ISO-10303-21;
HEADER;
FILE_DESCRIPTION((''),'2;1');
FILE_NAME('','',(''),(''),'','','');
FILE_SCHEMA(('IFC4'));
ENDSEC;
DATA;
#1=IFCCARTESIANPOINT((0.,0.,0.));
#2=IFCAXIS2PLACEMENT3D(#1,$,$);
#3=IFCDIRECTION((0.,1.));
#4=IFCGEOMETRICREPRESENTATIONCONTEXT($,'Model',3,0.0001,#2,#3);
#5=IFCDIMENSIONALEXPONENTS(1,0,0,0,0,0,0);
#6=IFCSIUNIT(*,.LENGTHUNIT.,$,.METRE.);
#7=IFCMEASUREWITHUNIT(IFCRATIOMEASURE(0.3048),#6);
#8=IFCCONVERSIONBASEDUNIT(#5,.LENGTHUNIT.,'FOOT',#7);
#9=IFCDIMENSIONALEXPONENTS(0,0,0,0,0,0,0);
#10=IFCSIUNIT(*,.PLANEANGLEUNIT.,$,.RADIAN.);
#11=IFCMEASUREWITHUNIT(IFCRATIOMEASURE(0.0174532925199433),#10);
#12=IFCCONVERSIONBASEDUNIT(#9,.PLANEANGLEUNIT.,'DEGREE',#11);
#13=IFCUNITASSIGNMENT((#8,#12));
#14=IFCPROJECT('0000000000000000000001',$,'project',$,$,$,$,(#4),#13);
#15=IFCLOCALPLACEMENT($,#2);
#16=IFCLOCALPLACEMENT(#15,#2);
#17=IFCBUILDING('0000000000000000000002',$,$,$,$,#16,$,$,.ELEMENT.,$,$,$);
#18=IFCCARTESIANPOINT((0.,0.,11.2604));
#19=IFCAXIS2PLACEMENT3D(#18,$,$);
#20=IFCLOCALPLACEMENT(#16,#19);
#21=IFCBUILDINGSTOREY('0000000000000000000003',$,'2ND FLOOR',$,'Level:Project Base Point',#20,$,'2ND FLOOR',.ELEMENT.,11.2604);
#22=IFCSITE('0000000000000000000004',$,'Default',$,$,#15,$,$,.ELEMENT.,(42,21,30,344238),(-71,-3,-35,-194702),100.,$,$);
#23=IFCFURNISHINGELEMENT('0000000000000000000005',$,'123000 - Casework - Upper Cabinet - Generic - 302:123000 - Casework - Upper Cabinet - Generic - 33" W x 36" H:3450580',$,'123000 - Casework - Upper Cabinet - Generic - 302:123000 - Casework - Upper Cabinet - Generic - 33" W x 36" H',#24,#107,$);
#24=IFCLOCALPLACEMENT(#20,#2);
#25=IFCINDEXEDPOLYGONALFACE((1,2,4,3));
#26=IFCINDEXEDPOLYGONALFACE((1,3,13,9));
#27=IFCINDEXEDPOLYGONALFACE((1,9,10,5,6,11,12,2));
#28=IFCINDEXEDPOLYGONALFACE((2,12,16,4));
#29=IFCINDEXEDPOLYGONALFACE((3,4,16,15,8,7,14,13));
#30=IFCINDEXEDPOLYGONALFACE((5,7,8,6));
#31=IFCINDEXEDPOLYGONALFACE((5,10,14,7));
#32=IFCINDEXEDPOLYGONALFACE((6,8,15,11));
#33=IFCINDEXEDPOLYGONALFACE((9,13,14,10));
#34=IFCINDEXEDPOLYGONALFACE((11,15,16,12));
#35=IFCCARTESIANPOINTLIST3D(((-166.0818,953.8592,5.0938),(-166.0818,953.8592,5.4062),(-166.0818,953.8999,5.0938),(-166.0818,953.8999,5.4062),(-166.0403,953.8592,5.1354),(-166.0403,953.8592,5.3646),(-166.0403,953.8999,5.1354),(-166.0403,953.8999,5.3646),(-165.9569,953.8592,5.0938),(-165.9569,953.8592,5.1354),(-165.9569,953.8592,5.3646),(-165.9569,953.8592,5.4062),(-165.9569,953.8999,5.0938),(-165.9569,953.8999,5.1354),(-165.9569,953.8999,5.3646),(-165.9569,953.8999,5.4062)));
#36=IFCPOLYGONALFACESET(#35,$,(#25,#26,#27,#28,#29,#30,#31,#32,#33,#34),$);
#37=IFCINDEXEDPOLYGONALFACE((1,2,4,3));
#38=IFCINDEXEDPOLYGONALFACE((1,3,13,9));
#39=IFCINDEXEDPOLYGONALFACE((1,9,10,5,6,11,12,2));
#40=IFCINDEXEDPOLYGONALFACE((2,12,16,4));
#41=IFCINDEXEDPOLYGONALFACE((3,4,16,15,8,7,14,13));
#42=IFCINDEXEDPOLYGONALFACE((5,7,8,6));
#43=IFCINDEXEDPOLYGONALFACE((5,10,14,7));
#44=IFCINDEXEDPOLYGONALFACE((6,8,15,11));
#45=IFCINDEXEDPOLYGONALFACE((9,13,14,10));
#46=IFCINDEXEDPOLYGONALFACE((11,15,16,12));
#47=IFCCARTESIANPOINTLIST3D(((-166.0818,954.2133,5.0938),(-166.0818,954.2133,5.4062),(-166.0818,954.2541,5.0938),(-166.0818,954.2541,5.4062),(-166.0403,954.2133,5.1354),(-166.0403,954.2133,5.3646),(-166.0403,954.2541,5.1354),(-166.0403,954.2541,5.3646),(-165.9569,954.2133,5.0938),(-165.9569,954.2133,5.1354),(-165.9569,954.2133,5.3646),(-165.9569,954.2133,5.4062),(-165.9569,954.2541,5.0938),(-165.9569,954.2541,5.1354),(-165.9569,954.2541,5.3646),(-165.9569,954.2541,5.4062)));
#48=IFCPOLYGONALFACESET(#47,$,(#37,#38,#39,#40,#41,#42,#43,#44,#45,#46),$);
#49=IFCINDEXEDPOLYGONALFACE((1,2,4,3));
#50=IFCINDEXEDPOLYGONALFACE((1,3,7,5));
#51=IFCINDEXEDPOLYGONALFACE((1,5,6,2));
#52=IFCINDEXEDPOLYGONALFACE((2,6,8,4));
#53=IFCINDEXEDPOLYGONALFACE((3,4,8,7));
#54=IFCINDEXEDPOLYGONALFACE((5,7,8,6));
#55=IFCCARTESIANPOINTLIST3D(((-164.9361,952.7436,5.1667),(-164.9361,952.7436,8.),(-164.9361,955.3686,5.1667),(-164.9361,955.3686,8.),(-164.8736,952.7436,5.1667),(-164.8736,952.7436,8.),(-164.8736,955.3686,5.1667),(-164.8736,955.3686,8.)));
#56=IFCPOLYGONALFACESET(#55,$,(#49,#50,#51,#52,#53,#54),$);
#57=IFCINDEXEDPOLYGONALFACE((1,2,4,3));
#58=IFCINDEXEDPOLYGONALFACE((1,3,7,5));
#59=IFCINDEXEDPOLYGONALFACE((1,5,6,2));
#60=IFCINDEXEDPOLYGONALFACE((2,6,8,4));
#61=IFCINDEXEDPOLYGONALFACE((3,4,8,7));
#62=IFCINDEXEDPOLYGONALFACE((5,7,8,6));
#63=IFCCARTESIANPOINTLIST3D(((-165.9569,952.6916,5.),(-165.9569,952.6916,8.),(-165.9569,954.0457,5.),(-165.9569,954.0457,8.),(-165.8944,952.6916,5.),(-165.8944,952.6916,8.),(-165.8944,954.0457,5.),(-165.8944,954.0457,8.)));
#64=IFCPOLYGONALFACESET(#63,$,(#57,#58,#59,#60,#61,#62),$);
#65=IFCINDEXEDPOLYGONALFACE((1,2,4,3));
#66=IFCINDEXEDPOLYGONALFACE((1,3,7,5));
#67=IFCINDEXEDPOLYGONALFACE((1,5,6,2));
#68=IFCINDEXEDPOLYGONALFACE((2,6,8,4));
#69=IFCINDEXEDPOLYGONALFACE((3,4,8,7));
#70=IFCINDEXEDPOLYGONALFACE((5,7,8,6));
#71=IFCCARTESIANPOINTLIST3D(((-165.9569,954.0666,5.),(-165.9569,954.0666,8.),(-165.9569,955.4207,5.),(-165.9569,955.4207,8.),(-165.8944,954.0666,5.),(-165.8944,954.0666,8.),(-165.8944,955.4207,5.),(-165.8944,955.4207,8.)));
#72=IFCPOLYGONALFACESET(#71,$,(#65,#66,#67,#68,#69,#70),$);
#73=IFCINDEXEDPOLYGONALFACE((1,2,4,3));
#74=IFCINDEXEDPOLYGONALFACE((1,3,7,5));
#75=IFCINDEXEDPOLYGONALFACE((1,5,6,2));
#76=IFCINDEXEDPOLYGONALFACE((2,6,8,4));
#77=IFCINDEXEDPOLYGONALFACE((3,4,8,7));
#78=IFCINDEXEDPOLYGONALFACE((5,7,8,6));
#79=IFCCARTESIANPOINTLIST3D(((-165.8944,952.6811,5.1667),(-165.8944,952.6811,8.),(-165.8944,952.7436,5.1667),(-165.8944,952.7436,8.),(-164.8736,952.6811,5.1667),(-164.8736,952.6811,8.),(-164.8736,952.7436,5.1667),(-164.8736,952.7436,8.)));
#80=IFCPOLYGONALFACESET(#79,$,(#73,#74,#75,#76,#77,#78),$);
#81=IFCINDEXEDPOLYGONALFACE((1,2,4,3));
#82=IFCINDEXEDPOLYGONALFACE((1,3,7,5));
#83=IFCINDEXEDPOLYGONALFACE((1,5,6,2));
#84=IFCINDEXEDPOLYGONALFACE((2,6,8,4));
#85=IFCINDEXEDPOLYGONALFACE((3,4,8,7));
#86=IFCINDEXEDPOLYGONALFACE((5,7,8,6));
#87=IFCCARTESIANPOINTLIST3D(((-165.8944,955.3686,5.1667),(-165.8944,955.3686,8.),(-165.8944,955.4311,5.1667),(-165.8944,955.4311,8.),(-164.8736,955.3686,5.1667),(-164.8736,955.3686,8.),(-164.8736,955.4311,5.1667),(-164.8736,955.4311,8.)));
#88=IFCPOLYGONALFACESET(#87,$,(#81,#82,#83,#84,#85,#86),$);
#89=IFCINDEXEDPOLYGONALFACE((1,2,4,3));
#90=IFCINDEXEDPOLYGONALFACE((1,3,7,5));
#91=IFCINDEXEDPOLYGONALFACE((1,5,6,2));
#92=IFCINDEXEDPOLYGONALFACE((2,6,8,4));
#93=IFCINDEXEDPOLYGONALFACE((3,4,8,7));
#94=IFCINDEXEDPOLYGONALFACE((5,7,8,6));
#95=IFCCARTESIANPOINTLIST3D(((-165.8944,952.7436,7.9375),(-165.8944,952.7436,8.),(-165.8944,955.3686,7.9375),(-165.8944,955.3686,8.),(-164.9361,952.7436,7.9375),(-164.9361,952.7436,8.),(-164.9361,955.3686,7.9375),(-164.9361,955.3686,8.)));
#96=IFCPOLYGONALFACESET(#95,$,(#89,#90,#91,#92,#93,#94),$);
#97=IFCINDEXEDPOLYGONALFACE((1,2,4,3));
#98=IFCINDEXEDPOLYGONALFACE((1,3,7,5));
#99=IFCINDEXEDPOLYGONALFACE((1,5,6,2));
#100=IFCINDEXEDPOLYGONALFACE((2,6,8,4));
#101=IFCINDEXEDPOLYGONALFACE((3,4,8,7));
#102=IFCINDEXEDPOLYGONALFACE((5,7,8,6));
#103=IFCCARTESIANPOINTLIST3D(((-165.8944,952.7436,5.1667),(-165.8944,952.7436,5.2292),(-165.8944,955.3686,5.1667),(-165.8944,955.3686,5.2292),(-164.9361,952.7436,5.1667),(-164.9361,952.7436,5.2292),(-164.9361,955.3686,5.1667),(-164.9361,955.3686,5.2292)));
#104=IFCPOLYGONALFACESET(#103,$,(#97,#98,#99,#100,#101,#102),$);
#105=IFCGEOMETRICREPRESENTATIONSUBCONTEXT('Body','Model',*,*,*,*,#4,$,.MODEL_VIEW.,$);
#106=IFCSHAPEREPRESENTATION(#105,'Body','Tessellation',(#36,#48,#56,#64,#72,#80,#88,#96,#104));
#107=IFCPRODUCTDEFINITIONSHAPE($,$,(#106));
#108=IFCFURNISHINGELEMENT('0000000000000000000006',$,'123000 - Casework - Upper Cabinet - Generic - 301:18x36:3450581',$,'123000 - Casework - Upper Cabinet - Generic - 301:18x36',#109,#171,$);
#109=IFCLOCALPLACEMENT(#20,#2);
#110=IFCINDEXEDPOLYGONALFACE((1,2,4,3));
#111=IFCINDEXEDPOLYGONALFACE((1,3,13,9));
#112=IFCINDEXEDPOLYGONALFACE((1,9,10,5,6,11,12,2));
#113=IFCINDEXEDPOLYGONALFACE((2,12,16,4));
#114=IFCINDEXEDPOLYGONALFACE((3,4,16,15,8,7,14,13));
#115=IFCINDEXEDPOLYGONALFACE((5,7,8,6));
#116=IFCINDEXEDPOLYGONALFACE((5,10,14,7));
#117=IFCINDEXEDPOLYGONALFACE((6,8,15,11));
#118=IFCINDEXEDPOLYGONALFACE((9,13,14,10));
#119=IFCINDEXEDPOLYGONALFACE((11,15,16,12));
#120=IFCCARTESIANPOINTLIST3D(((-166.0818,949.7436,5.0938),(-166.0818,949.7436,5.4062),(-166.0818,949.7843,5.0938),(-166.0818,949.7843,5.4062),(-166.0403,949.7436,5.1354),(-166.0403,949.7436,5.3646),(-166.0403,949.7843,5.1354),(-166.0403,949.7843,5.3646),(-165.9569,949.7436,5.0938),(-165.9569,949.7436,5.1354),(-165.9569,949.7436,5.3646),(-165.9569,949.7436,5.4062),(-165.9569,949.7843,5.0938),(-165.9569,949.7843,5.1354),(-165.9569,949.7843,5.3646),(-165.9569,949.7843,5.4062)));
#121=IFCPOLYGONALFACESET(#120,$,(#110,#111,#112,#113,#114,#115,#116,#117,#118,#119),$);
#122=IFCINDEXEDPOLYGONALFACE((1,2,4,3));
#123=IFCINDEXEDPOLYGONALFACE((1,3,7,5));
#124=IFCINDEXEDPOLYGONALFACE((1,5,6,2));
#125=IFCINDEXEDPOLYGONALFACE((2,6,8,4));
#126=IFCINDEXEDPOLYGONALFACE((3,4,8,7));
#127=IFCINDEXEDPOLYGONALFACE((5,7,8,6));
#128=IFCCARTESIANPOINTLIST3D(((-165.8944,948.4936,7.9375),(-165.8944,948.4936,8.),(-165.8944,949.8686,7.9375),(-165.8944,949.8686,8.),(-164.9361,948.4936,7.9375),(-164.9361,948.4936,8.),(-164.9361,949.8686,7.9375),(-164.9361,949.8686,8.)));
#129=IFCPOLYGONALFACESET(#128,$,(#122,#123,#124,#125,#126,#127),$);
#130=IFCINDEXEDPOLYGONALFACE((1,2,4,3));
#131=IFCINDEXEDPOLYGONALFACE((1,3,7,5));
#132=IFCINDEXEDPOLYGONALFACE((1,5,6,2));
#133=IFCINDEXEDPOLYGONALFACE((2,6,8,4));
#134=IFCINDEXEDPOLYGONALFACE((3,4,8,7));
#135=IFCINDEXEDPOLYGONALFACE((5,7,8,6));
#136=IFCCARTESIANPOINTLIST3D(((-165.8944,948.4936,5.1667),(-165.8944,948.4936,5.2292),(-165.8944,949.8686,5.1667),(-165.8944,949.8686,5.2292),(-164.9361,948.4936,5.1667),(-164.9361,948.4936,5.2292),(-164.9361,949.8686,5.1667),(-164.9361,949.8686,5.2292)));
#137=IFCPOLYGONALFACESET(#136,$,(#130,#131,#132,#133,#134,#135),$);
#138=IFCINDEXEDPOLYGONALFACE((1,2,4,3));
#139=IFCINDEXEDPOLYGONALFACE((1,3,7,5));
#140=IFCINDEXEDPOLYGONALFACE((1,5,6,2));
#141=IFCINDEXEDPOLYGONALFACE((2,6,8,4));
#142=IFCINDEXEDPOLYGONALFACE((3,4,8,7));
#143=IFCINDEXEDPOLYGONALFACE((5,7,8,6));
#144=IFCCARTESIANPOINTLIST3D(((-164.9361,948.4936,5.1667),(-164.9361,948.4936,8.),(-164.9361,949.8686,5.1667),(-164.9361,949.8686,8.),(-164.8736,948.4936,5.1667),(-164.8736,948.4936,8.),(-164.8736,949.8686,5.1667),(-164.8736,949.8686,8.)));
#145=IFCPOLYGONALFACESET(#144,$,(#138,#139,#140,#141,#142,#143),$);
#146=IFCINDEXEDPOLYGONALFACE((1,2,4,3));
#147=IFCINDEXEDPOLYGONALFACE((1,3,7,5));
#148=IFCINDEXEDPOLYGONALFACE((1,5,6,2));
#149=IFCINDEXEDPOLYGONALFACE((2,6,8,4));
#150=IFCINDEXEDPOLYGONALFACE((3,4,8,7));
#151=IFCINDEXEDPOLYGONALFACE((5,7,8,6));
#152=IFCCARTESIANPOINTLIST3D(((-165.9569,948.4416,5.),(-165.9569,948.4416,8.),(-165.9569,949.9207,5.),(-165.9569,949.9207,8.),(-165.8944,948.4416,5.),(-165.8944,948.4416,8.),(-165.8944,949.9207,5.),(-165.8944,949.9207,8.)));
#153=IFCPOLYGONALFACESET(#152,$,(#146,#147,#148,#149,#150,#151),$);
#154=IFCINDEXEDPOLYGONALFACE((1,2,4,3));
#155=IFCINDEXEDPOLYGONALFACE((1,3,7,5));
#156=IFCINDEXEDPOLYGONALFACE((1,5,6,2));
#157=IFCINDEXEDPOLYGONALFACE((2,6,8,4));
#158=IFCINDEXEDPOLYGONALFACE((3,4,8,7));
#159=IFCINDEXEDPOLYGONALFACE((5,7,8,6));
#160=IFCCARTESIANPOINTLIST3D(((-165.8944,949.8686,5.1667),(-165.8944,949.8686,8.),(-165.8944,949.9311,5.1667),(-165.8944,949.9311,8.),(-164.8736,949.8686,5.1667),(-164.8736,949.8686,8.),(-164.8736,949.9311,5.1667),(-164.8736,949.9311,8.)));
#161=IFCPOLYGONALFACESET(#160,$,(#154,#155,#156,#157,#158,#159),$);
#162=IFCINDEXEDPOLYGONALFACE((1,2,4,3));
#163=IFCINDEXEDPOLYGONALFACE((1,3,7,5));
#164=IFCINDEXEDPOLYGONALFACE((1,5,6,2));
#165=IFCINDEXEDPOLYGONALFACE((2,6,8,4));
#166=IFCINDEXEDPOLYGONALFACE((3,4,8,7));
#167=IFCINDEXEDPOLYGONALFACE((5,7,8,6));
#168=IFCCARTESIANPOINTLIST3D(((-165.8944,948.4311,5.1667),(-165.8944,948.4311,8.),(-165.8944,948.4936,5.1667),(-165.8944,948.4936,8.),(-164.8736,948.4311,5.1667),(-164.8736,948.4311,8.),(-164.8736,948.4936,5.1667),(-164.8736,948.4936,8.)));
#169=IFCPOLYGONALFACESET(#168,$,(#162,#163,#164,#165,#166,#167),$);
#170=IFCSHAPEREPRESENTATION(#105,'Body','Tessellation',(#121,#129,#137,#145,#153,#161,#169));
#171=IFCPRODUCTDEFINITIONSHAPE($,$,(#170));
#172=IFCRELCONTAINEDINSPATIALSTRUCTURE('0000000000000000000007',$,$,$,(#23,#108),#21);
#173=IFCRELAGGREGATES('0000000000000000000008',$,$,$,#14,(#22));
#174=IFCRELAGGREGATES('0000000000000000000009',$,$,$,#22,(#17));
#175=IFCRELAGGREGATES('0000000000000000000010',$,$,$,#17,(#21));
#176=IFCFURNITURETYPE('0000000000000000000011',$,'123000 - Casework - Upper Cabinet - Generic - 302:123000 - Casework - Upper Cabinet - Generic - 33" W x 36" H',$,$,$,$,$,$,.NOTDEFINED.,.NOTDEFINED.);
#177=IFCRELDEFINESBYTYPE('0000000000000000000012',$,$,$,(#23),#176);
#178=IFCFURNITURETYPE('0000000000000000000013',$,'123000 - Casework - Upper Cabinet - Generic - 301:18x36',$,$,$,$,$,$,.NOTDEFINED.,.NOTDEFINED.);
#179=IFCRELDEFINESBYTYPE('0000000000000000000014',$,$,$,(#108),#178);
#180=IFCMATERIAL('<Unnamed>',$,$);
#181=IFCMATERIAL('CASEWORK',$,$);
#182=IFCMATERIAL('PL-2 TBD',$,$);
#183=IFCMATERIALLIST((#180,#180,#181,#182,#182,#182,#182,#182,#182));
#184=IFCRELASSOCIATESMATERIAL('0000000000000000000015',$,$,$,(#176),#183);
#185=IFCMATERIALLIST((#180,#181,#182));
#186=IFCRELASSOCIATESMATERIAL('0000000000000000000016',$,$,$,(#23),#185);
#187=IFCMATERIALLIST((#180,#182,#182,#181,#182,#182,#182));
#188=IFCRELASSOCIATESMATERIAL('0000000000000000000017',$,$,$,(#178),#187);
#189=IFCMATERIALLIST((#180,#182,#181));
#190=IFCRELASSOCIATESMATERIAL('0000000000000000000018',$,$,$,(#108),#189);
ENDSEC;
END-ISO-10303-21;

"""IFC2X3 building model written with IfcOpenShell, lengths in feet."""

from ifc_helpers import new_model, entity, si_unit, converted_unit, direction, frame, frame_2d, origin, origin_2d_with_axis, place, context, subcontext, project, spatial, polyline, rectangle, outline, extrude, source, transform, mapped, material, material_list, type_object, type_shapes, element, save


model = new_model("IFC2X3")

# Units and contexts
model_context = context("Model", 3, precision=0.0001, world=origin(), true_north=direction((0.0, 1.0)))
body_context = subcontext(model_context, "Body", "Model", "MODEL_VIEW")
ifc_project = project(units=[converted_unit("LENGTHUNIT", "FOOT", entity("IfcRatioMeasure", 0.3048), si_unit("LENGTHUNIT", "METRE"), dimensions=[1, 0, 0, 0, 0, 0, 0]), converted_unit("PLANEANGLEUNIT", "DEGREE", entity("IfcRatioMeasure", 0.0174532925199433), si_unit("PLANEANGLEUNIT", "RADIAN"), dimensions=[0, 0, 0, 0, 0, 0, 0])], contexts=[model_context])

# Site, building, storey
site_placement = place(None, origin())
site = spatial("IfcSite", under=ifc_project, at=site_placement, Name="Default", CompositionType="ELEMENT", RefLatitude=(42, 21, 30, 344238), RefLongitude=(-71, -3, -35, -194702), RefElevation=100.0)
building_placement = place(site_placement, origin())
building = spatial("IfcBuilding", under=site, at=building_placement, CompositionType="ELEMENT")
storey_placement = place(building_placement, frame((0.0, 0.0, 11.2604)))
storey = spatial("IfcBuildingStorey", under=building, at=storey_placement, Name="2ND FLOOR", ObjectType="Level:Project Base Point", LongName="2ND FLOOR", CompositionType="ELEMENT", Elevation=11.2604)

# Furnishing elements
ifc_material_1 = material(Name="<Unnamed>")
ifc_material_2 = material(Name="CASEWORK")
ifc_material_3 = material(Name="PL-2 TBD")
ifc_material_list_1 = material_list([ifc_material_1, ifc_material_2, ifc_material_3])
ifc_material_list_2 = material_list([ifc_material_1, ifc_material_1, ifc_material_2, ifc_material_3, ifc_material_3, ifc_material_3, ifc_material_3, ifc_material_3, ifc_material_3])
furniture_type_1 = type_object("IfcFurnitureType", Name="123000 - Casework - Upper Cabinet - Generic - 302:123000 - Casework - Upper Cabinet - Generic - 33\" W x 36\" H", material=ifc_material_list_2)
shared_shape_1 = source(origin(), body_context, "Body", "SweptSolid", [
    extrude(outline(polyline([(-0.0521, -0.1146), (-0.0521, -0.1562), (0.0729, -0.1562), (0.0729, 0.1562), (-0.0521, 0.1562), (-0.0521, 0.1146), (0.0313, 0.1146), (0.0313, -0.1146), (-0.0521, -0.1146)])), frame((1.178, 1.1354, 0.25), z_axis=(-1.0, 0.0, 0.0), x_axis=(0.0, 1.0, 0.0)), (0.0, 0.0, -1.0), 0.0407),
    extrude(outline(polyline([(-0.0521, -0.1146), (-0.0521, -0.1562), (0.0729, -0.1562), (0.0729, 0.1562), (-0.0521, 0.1562), (-0.0521, 0.1146), (0.0313, 0.1146), (0.0313, -0.1146), (-0.0521, -0.1146)])), frame((1.5322, 1.1354, 0.25), z_axis=(-1.0, 0.0, 0.0), x_axis=(0.0, 1.0, 0.0)), (0.0, 0.0, -1.0), 0.0407),
    extrude(rectangle(XDim=2.625, YDim=0.0625, at=frame_2d((0.0, 0.0), x_axis=(1.0, 0.0))), frame((1.375, 0.0313, 0.1667), z_axis=(0.0, 0.0, 1.0), x_axis=(-1.0, 0.0, 0.0)), (0.0, 0.0, 1.0), 2.8333),
    extrude(rectangle(XDim=1.3542, YDim=0.0625, at=origin_2d_with_axis()), frame((0.6875, 1.0521, 0.0)), (0.0, 0.0, 1.0), 3.0),
    extrude(rectangle(XDim=1.3542, YDim=0.0625, at=origin_2d_with_axis()), frame((2.0625, 1.0521, 0.0)), (0.0, 0.0, 1.0), 3.0),
    extrude(rectangle(XDim=1.0208, YDim=0.0625, at=origin_2d_with_axis()), frame((0.0312, 0.5104, 0.1667), z_axis=(0.0, 0.0, 1.0), x_axis=(0.0, 1.0, 0.0)), (0.0, 0.0, 1.0), 2.8333),
    extrude(rectangle(XDim=1.0208, YDim=0.0625, at=frame_2d((0.0, 0.0), x_axis=(1.0, 0.0))), frame((2.7188, 0.5104, 0.1667), z_axis=(0.0, 0.0, 1.0), x_axis=(0.0, 1.0, 0.0)), (0.0, 0.0, 1.0), 2.8333),
    extrude(rectangle(XDim=0.9583, YDim=2.625, at=frame_2d((0.0, 0.0), x_axis=(1.0, 0.0))), frame((1.375, 0.5417, 2.9375), z_axis=(0.0, 0.0, 1.0), x_axis=(0.0, 1.0, 0.0)), (0.0, 0.0, 1.0), 0.0625),
    extrude(rectangle(XDim=0.9583, YDim=2.625, at=frame_2d((0.0, 0.0), x_axis=(1.0, 0.0))), frame((1.375, 0.5417, 0.1667), z_axis=(0.0, 0.0, 1.0), x_axis=(0.0, 1.0, 0.0)), (0.0, 0.0, 1.0), 0.0625),
])
type_shapes(furniture_type_1, [shared_shape_1])
furnishing_1_placement = place(storey_placement, frame((-164.8736, 952.6811, 5.0), z_axis=(0.0, 0.0, 1.0), x_axis=(0.0, 1.0, 0.0)))
element("IfcFurnishingElement", 1, at=furnishing_1_placement, inside=storey, type_object=furniture_type_1, material=ifc_material_list_1, Name="123000 - Casework - Upper Cabinet - Generic - 302:123000 - Casework - Upper Cabinet - Generic - 33\" W x 36\" H:3450580", ObjectType="123000 - Casework - Upper Cabinet - Generic - 302:123000 - Casework - Upper Cabinet - Generic - 33\" W x 36\" H", context=body_context, shape_type="MappedRepresentation", body=[
    mapped(shared_shape_1, transform((0.0, 0.0, 0.0), scale=1.0)),
])
ifc_material_list_3 = material_list([ifc_material_1, ifc_material_3, ifc_material_2])
ifc_material_list_4 = material_list([ifc_material_1, ifc_material_3, ifc_material_3, ifc_material_2, ifc_material_3, ifc_material_3, ifc_material_3])
furniture_type_2 = type_object("IfcFurnitureType", Name="123000 - Casework - Upper Cabinet - Generic - 301:18x36", material=ifc_material_list_4)
shared_shape_2 = source(origin(), body_context, "Body", "SweptSolid", [
    extrude(outline(polyline([(0.1146, -0.0521), (0.1562, -0.0521), (0.1562, 0.0729), (-0.1562, 0.0729), (-0.1562, -0.0521), (-0.1146, -0.0521), (-0.1146, 0.0313), (0.1146, 0.0313), (0.1146, -0.0521)])), frame((0.1468, 0.0729, 0.25), z_axis=(1.0, 0.0, 0.0), x_axis=(0.0, 0.0, 1.0)), (0.0, 0.0, 1.0), 0.0407),
    extrude(rectangle(XDim=1.375, YDim=0.9583, at=frame_2d((0.0, 0.0), x_axis=(1.0, 0.0))), frame((0.75, 0.6666, 2.9375), z_axis=(0.0, 0.0, 1.0), x_axis=(-1.0, 0.0, 0.0)), (0.0, 0.0, 1.0), 0.0625),
    extrude(rectangle(XDim=1.375, YDim=0.9583, at=frame_2d((0.0, 0.0), x_axis=(1.0, 0.0))), frame((0.75, 0.6666, 0.1667), z_axis=(0.0, 0.0, 1.0), x_axis=(-1.0, 0.0, 0.0)), (0.0, 0.0, 1.0), 0.0625),
    extrude(rectangle(XDim=0.0625, YDim=1.375, at=origin_2d_with_axis()), frame((0.75, 1.177, 0.1667), z_axis=(0.0, 0.0, 1.0), x_axis=(0.0, 1.0, 0.0)), (0.0, 0.0, 1.0), 2.8333),
    extrude(rectangle(XDim=0.0625, YDim=1.4792, at=origin_2d_with_axis()), frame((0.75, 0.1562, 0.0), z_axis=(0.0, 0.0, 1.0), x_axis=(0.0, -1.0, 0.0)), (0.0, 0.0, 1.0), 3.0),
    extrude(rectangle(XDim=0.0625, YDim=1.0208, at=origin_2d_with_axis()), frame((0.0312, 0.6979, 0.1667), z_axis=(0.0, 0.0, 1.0), x_axis=(-1.0, 0.0, 0.0)), (0.0, 0.0, 1.0), 2.8333),
    extrude(rectangle(XDim=0.0625, YDim=1.0208, at=origin_2d_with_axis()), frame((1.4688, 0.6979, 0.1667), z_axis=(0.0, 0.0, 1.0), x_axis=(-1.0, 0.0, 0.0)), (0.0, 0.0, 1.0), 2.8333),
])
type_shapes(furniture_type_2, [shared_shape_2])
furnishing_2_placement = place(storey_placement, frame((-166.0818, 949.9311, 5.0), z_axis=(0.0, 0.0, 1.0), x_axis=(0.0, -1.0, 0.0)))
element("IfcFurnishingElement", 2, at=furnishing_2_placement, inside=storey, type_object=furniture_type_2, material=ifc_material_list_3, Name="123000 - Casework - Upper Cabinet - Generic - 301:18x36:3450581", ObjectType="123000 - Casework - Upper Cabinet - Generic - 301:18x36", context=body_context, shape_type="MappedRepresentation", body=[
    mapped(shared_shape_2, transform((0.0, 0.0, 0.0), scale=1.0)),
])

save(model, "model.ifc")
